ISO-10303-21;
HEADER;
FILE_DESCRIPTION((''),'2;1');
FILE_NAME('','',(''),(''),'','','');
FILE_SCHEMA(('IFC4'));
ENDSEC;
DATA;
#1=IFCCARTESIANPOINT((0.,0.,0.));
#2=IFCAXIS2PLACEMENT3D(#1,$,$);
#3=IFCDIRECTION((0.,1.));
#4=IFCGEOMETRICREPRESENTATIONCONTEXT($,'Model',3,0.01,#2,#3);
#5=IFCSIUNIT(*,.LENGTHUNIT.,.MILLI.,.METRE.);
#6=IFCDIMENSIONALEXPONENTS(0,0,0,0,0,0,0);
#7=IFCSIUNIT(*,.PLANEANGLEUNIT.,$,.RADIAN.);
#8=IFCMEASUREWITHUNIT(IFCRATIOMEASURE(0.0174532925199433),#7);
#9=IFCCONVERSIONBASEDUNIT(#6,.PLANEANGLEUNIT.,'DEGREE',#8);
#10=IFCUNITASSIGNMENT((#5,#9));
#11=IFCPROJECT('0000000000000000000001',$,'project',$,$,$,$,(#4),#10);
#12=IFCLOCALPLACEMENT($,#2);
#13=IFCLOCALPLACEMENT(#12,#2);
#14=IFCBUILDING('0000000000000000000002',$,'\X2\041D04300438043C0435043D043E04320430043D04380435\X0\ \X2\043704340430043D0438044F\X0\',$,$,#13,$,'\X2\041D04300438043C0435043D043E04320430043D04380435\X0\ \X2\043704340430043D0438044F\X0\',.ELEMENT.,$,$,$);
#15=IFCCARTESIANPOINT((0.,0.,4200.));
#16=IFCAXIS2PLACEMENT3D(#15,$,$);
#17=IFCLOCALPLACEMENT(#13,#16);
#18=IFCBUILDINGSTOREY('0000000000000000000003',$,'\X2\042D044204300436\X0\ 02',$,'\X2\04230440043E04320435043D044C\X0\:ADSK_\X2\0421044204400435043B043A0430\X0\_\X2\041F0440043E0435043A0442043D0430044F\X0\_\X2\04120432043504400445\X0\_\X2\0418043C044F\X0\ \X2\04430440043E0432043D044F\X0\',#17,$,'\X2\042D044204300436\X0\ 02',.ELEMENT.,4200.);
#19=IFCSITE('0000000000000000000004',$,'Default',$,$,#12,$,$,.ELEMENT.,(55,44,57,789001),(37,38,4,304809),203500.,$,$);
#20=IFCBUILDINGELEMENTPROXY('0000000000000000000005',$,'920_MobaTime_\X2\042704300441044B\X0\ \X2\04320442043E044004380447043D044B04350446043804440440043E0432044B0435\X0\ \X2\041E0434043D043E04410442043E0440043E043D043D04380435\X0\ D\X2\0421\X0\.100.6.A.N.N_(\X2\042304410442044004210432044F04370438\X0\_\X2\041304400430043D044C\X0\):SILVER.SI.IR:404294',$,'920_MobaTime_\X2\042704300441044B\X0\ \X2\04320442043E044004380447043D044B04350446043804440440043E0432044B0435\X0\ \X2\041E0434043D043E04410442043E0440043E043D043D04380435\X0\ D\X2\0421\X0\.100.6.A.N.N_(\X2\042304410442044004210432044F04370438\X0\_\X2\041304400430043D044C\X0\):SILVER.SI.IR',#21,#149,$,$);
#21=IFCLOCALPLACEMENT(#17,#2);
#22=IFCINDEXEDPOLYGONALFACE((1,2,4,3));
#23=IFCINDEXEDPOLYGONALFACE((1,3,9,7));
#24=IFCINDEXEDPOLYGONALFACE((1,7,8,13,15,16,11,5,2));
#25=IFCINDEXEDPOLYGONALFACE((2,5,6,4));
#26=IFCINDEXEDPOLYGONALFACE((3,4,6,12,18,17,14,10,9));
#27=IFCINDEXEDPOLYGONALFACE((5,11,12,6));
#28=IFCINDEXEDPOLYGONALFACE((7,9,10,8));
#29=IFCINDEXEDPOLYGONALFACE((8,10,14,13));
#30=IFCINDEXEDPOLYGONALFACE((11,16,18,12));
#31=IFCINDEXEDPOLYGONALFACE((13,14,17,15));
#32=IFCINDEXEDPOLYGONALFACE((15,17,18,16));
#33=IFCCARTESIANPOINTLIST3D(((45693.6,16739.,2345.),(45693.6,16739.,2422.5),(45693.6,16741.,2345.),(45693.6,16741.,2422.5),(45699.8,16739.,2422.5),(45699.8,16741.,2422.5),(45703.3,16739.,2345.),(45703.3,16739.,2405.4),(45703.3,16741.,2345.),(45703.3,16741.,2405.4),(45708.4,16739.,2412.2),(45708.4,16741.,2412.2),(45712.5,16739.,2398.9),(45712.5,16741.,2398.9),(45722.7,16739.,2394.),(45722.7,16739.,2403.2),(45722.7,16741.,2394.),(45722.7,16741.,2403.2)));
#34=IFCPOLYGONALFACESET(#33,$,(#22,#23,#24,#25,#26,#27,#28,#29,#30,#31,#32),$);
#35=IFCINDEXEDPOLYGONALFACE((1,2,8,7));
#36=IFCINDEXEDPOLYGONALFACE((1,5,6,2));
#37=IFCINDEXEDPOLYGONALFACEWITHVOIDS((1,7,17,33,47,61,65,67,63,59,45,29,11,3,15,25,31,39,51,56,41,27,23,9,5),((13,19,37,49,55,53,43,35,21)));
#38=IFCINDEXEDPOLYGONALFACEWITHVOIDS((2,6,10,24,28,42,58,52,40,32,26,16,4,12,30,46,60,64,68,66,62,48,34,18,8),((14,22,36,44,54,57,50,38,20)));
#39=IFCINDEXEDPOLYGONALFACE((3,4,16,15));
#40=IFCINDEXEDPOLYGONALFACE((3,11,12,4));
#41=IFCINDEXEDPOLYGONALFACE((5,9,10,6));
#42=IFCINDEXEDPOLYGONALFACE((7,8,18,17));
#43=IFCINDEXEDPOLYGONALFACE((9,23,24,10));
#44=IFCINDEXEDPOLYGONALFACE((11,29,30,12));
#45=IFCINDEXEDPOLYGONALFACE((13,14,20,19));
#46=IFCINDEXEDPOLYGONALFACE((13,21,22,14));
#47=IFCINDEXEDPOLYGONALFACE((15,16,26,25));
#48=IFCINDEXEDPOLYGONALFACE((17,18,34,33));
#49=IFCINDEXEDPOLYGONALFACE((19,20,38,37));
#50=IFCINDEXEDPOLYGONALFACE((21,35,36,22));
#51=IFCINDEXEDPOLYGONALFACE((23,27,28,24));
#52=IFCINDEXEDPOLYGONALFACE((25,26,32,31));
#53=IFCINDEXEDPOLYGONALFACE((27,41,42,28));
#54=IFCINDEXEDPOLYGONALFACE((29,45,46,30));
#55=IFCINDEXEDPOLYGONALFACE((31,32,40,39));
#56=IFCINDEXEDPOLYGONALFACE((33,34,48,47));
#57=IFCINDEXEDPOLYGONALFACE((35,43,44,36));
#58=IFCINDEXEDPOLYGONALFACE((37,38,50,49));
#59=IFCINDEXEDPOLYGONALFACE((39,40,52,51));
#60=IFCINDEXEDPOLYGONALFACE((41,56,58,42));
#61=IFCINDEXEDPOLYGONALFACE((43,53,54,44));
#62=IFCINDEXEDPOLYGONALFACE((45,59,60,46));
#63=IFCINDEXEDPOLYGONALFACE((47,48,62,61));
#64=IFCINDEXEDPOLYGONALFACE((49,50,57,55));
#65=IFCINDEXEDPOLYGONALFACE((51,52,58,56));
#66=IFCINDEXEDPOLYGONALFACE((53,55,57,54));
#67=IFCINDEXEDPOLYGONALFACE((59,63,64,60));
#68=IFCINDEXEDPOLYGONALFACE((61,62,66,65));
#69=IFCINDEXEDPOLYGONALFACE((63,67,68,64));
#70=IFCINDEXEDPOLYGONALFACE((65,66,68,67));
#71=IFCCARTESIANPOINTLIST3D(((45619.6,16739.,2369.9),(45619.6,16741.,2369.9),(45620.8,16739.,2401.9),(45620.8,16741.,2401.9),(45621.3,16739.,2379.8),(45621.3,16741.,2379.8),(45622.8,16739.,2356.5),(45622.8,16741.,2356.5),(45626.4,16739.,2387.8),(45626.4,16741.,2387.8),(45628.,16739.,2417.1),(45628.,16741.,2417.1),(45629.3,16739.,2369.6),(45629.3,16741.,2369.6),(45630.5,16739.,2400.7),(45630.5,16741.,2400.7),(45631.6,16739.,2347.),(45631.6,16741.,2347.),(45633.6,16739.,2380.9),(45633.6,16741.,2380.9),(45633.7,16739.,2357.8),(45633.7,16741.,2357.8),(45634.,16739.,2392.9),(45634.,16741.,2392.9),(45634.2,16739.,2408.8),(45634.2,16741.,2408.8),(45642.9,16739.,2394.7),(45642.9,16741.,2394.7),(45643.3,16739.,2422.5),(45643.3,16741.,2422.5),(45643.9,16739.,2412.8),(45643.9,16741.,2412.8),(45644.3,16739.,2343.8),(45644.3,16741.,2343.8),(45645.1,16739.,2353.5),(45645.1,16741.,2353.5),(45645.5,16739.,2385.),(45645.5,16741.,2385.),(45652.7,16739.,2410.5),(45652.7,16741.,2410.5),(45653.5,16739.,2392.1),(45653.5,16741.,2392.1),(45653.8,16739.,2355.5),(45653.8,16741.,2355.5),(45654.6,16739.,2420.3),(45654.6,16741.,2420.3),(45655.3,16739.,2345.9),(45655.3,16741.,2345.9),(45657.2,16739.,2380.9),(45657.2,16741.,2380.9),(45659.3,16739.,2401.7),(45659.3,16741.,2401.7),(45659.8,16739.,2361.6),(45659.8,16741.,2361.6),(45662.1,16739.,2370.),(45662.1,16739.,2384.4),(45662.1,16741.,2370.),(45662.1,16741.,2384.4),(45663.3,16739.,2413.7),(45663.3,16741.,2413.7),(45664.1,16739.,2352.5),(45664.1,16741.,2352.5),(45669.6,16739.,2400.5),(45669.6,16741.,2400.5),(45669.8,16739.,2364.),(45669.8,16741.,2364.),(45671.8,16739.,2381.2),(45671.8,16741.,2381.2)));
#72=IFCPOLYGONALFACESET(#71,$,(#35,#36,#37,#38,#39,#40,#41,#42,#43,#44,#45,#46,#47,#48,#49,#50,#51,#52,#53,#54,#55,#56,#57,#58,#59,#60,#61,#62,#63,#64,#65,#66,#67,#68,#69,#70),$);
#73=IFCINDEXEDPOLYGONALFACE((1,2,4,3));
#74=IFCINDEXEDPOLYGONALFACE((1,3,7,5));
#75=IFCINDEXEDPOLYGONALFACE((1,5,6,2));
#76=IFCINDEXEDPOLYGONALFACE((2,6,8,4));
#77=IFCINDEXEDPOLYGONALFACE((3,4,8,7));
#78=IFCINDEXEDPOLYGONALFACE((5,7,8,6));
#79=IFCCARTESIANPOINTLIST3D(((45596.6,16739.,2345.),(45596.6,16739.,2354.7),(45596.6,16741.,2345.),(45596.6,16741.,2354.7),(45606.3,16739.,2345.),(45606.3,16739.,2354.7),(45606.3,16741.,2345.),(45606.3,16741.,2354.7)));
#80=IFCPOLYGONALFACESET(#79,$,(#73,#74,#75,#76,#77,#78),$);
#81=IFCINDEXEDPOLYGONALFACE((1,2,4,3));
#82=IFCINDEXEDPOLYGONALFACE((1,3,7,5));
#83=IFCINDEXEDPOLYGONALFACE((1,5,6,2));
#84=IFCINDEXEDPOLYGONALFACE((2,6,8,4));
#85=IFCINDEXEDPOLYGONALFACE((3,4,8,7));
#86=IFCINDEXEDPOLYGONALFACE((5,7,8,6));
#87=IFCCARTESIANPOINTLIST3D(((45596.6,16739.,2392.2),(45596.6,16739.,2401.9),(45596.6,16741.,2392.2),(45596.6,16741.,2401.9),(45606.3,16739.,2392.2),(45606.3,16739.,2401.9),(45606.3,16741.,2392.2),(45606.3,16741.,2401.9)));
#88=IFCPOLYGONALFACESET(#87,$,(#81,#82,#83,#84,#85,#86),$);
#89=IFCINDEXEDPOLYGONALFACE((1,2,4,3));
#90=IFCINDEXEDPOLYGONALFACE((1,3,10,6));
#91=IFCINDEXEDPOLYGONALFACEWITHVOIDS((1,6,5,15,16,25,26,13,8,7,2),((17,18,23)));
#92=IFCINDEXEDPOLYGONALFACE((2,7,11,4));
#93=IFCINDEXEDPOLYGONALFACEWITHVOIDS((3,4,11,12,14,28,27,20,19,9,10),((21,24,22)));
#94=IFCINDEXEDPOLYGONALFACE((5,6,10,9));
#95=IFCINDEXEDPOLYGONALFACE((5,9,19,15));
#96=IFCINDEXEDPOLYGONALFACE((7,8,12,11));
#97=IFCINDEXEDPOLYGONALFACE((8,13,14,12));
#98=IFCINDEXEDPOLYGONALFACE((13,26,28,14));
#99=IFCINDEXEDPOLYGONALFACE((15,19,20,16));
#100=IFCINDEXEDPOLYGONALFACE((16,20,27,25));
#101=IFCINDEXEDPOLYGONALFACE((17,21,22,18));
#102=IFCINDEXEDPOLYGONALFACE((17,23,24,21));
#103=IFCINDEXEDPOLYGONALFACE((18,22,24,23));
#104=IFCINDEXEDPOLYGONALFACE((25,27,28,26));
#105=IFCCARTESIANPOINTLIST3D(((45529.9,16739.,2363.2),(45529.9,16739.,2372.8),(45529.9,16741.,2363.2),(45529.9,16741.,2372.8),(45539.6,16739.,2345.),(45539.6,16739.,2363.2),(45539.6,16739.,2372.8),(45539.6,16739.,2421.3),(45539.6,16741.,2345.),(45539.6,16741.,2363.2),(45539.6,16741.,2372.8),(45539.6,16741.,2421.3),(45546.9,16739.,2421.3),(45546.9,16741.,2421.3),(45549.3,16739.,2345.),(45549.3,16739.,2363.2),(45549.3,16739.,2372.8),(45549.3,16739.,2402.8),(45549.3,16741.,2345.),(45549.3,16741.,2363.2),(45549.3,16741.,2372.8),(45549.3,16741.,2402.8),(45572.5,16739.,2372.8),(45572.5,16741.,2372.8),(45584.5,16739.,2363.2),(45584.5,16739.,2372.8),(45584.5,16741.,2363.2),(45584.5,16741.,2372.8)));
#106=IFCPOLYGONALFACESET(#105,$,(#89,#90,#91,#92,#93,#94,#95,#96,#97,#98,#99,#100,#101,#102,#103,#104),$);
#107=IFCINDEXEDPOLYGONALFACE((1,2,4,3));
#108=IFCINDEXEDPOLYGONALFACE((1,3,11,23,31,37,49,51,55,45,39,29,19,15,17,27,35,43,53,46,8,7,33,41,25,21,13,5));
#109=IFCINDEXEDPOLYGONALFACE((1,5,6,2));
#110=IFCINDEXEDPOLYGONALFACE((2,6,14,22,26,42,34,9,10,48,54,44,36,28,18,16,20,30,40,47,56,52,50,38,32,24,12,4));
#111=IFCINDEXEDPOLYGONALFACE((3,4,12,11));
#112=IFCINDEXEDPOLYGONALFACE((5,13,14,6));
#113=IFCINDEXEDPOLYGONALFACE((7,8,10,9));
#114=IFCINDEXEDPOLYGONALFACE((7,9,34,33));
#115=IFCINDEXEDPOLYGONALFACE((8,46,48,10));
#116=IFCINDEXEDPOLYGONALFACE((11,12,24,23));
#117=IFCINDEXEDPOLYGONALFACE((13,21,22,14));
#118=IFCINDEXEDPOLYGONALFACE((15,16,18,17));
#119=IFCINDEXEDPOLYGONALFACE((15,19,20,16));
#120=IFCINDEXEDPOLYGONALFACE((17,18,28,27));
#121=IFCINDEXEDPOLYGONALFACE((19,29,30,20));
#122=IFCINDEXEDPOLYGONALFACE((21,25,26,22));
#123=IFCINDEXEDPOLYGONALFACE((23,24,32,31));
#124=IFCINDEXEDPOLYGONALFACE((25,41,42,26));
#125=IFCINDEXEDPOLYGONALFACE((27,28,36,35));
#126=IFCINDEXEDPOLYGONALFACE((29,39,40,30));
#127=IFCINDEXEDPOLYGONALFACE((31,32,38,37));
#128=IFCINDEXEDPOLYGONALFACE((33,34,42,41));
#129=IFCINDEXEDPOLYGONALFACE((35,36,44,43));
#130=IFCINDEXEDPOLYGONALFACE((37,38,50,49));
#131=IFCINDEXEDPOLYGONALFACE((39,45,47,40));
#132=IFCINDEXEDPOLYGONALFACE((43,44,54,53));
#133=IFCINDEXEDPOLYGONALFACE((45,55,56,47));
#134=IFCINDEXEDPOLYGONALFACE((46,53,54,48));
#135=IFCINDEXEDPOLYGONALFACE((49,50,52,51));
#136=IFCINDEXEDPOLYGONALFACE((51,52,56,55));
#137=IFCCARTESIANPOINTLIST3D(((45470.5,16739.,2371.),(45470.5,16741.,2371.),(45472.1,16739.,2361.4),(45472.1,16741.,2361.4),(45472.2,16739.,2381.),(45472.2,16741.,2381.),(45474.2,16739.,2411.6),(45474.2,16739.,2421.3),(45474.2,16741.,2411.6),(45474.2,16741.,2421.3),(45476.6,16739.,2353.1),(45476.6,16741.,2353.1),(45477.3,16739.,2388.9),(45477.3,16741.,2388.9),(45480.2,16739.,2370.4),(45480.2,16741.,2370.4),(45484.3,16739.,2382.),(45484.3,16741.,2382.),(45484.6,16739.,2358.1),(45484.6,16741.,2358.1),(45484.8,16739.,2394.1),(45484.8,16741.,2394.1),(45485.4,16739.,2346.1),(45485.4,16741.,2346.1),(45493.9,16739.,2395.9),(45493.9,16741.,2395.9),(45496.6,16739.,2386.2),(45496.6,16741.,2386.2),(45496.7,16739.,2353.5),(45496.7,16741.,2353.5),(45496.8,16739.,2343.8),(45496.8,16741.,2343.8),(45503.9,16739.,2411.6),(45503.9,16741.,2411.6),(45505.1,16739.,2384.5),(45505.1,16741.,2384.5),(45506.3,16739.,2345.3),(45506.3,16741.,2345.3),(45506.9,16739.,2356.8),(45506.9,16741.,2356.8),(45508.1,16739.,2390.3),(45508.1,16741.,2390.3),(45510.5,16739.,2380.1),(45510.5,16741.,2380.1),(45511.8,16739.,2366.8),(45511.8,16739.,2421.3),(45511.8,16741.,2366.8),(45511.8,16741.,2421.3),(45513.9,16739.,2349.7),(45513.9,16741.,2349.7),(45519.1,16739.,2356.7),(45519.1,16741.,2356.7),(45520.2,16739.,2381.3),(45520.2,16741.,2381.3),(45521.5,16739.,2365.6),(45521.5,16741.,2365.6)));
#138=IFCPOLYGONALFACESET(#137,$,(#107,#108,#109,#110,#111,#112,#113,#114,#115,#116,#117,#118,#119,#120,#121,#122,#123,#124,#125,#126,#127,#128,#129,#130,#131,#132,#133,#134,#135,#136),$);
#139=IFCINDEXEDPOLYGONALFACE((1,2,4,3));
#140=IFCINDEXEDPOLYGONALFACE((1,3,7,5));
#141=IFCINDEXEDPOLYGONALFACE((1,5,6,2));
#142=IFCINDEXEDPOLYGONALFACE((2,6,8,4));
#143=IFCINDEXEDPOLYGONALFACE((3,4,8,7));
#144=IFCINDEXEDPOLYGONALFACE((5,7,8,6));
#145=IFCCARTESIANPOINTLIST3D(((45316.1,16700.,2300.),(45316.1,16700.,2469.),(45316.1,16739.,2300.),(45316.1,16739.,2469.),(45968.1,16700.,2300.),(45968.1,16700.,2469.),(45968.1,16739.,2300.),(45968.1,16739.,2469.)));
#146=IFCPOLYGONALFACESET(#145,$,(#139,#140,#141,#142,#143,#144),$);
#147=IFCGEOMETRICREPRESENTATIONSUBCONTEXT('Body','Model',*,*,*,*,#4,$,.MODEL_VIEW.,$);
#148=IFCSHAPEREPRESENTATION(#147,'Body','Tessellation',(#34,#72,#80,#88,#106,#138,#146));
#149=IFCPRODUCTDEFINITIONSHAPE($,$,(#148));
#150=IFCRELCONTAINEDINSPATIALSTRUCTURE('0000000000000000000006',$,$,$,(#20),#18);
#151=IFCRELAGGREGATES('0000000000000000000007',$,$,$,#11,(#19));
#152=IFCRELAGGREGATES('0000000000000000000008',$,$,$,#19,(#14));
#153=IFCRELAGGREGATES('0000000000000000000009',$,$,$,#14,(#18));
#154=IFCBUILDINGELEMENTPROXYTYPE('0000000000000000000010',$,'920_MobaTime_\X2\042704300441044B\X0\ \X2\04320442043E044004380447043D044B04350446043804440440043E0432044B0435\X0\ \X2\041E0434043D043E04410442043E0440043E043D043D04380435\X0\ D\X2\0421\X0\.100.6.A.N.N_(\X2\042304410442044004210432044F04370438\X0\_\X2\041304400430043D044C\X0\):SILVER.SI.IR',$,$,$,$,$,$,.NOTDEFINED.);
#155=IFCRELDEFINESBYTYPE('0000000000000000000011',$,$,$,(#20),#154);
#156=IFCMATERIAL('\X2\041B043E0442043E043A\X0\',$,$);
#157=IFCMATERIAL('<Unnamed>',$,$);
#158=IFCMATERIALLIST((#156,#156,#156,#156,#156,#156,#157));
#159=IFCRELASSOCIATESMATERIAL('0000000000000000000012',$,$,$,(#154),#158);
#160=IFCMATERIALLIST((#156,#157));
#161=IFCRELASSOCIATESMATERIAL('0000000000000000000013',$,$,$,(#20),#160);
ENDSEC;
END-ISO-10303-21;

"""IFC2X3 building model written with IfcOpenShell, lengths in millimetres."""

from ifc_helpers import new_model, entity, si_unit, converted_unit, direction, frame, origin, origin_2d_with_axis, place, context, subcontext, project, spatial, polyline, rectangle, outline, extrude, source, transform, mapped, material, material_list, type_object, type_shapes, element, save


model = new_model("IFC2X3")

# Units and contexts
model_context = context("Model", 3, precision=0.01, world=origin(), true_north=direction((0.0, 1.0)))
body_context = subcontext(model_context, "Body", "Model", "MODEL_VIEW")
ifc_project = project(units=[si_unit("LENGTHUNIT", "METRE", prefix="MILLI"), converted_unit("PLANEANGLEUNIT", "DEGREE", entity("IfcRatioMeasure", 0.0174532925199433), si_unit("PLANEANGLEUNIT", "RADIAN"), dimensions=[0, 0, 0, 0, 0, 0, 0])], contexts=[model_context])

# Site, building, storey
site_placement = place(None, frame((0.0, 0.0, 0.0)))
site = spatial("IfcSite", under=ifc_project, at=site_placement, Name="Default", CompositionType="ELEMENT", RefLatitude=(55, 44, 57, 789001), RefLongitude=(37, 38, 4, 304809), RefElevation=203500.0)
building_placement = place(site_placement, origin())
building = spatial("IfcBuilding", under=site, at=building_placement, Name="Наименование здания", LongName="Наименование здания", CompositionType="ELEMENT")
storey_placement = place(building_placement, frame((0.0, 0.0, 4200.0)))
storey = spatial("IfcBuildingStorey", under=building, at=storey_placement, Name="Этаж 02", ObjectType="Уровень:ADSK_Стрелка_Проектная_Вверх_Имя уровня", LongName="Этаж 02", CompositionType="ELEMENT", Elevation=4200.0)

# Building element proxy
ifc_material_1 = material(Name="Лоток")
ifc_material_2 = material(Name="<Unnamed>")
ifc_material_list_1 = material_list([ifc_material_1, ifc_material_1, ifc_material_1, ifc_material_1, ifc_material_1, ifc_material_1, ifc_material_2])
building_element_proxy_type_1 = type_object("IfcBuildingElementProxyType", Name="920_MobaTime_Часы вторичныецифровые Односторонние DС.100.6.A.N.N_(УстрСвязи_Грань):SILVER.SI.IR", PredefinedType="NOTDEFINED", material=ifc_material_list_1)
shared_shape_1 = source(origin(), body_context, "Body", "SweptSolid", [
    extrude(outline(polyline([(-49.3, -13.1), (28.2, -13.1), (28.2, -6.8), (17.9, 1.8), (8.9, 16.0), (-0.3, 16.0), (4.6, 5.8), (11.1, -3.4), (-49.3, -3.4), (-49.3, -13.1)])), frame((-64.6, 9.8, 39.0), z_axis=(0.0, 0.0, 1.0), x_axis=(0.0, 1.0, 0.0)), (0.0, 0.0, 1.0), 2.0),
    extrude(outline(polyline([(2.2, -27.6), (19.0, -27.6), (30.5, -16.1), (33.3, -4.9), (31.0, 5.8), (21.8, 17.2), (5.2, 27.3), (-11.1, 33.0), (-24.0, 32.7), (-33.6, 27.6), (-40.3, 18.6), (-42.8, 5.7), (-38.0, -6.3), (-27.2, -15.0), (-17.5, -17.7), (-8.2, -16.4), (-0.3, -11.9), (5.1, -4.5), (7.3, 6.2), (4.0, 17.2), (18.5, 7.3), (23.6, -2.4), (22.0, -11.4), (14.2, -18.4), (5.3, -18.3), (2.2, -27.6)]), holes=[polyline([(-9.0, 23.3), (-1.3, 14.4), (-2.6, 2.0), (-11.4, -7.0), (-23.4, -6.1), (-32.2, 2.9), (-31.2, 15.1), (-25.6, 22.1), (-17.5, 24.9), (-9.0, 23.3)])]), frame((-2.7, 3.6, 39.0), z_axis=(0.0, 0.0, 1.0), x_axis=(-0.427649, 0.903945, 0.0)), (0.0, 0.0, 1.0), 2.0),
    extrude(rectangle(XDim=9.7, YDim=9.7, at=origin_2d_with_axis()), frame((40.6, -34.7, 39.0)), (0.0, 0.0, 1.0), 2.0),
    extrude(rectangle(XDim=9.7, YDim=9.7, at=origin_2d_with_axis()), frame((40.6, 12.6, 39.0)), (0.0, 0.0, 1.0), 2.0),
    extrude(outline(polyline([(-0.9, -28.1), (8.8, -28.1), (8.8, -9.9), (18.5, -9.9), (18.5, -0.2), (8.8, -0.2), (8.8, 48.3), (1.5, 48.3), (-36.0, -0.2), (-36.0, -9.9), (-0.9, -9.9), (-0.9, -28.1)]), holes=[polyline([(-0.9, -0.2), (-24.1, -0.2), (-0.9, 29.7), (-0.9, -0.2)])]), frame((93.6, -11.4, 39.0)), (0.0, 0.0, 1.0), 2.0),
    extrude(outline(polyline([(3.3, -28.3), (12.5, -28.3), (20.5, -25.0), (26.8, -18.8), (30.7, -10.0), (31.4, 1.6), (26.9, 11.8), (20.1, 18.4), (11.1, 22.3), (1.0, 23.3), (-7.9, 20.4), (-14.9, 14.5), (-18.9, 6.2), (-17.1, -9.0), (-36.7, 0.5), (-29.1, 29.3), (-38.5, 31.7), (-48.1, -4.6), (-11.6, -23.0), (-8.0, -14.0), (-10.8, -7.6), (-10.2, 1.1), (-3.0, 11.8), (9.2, 12.8), (20.0, 5.4), (21.3, -7.5), (15.5, -16.4), (4.6, -18.6), (3.3, -28.3)])), frame((147.1, -8.5, 39.0), z_axis=(0.0, 0.0, 1.0), x_axis=(0.256974, -0.966418, 0.0)), (0.0, 0.0, 1.0), 2.0),
    extrude(rectangle(XDim=652.0, YDim=169.0, at=origin_2d_with_axis()), frame((0.0, 0.0, 0.0), z_axis=(0.0, 0.0, 1.0), x_axis=(-1.0, 0.0, 0.0)), (0.0, 0.0, 1.0), 39.0),
])
type_shapes(building_element_proxy_type_1, [shared_shape_1])
ifc_material_list_2 = material_list([ifc_material_1, ifc_material_2])
proxy_1_placement = place(storey_placement, frame((45642.1, 16700.0, 2384.5), z_axis=(0.0, 1.0, 0.0), x_axis=(-1.0, 0.0, 0.0)))
element("IfcBuildingElementProxy", 1, at=proxy_1_placement, inside=storey, type_object=building_element_proxy_type_1, material=ifc_material_list_2, Name="920_MobaTime_Часы вторичныецифровые Односторонние DС.100.6.A.N.N_(УстрСвязи_Грань):SILVER.SI.IR:404294", ObjectType="920_MobaTime_Часы вторичныецифровые Односторонние DС.100.6.A.N.N_(УстрСвязи_Грань):SILVER.SI.IR", context=body_context, shape_type="MappedRepresentation", body=[
    mapped(shared_shape_1, transform((0.0, 0.0, 0.0), scale=1.0)),
])

save(model, "model.ifc")
